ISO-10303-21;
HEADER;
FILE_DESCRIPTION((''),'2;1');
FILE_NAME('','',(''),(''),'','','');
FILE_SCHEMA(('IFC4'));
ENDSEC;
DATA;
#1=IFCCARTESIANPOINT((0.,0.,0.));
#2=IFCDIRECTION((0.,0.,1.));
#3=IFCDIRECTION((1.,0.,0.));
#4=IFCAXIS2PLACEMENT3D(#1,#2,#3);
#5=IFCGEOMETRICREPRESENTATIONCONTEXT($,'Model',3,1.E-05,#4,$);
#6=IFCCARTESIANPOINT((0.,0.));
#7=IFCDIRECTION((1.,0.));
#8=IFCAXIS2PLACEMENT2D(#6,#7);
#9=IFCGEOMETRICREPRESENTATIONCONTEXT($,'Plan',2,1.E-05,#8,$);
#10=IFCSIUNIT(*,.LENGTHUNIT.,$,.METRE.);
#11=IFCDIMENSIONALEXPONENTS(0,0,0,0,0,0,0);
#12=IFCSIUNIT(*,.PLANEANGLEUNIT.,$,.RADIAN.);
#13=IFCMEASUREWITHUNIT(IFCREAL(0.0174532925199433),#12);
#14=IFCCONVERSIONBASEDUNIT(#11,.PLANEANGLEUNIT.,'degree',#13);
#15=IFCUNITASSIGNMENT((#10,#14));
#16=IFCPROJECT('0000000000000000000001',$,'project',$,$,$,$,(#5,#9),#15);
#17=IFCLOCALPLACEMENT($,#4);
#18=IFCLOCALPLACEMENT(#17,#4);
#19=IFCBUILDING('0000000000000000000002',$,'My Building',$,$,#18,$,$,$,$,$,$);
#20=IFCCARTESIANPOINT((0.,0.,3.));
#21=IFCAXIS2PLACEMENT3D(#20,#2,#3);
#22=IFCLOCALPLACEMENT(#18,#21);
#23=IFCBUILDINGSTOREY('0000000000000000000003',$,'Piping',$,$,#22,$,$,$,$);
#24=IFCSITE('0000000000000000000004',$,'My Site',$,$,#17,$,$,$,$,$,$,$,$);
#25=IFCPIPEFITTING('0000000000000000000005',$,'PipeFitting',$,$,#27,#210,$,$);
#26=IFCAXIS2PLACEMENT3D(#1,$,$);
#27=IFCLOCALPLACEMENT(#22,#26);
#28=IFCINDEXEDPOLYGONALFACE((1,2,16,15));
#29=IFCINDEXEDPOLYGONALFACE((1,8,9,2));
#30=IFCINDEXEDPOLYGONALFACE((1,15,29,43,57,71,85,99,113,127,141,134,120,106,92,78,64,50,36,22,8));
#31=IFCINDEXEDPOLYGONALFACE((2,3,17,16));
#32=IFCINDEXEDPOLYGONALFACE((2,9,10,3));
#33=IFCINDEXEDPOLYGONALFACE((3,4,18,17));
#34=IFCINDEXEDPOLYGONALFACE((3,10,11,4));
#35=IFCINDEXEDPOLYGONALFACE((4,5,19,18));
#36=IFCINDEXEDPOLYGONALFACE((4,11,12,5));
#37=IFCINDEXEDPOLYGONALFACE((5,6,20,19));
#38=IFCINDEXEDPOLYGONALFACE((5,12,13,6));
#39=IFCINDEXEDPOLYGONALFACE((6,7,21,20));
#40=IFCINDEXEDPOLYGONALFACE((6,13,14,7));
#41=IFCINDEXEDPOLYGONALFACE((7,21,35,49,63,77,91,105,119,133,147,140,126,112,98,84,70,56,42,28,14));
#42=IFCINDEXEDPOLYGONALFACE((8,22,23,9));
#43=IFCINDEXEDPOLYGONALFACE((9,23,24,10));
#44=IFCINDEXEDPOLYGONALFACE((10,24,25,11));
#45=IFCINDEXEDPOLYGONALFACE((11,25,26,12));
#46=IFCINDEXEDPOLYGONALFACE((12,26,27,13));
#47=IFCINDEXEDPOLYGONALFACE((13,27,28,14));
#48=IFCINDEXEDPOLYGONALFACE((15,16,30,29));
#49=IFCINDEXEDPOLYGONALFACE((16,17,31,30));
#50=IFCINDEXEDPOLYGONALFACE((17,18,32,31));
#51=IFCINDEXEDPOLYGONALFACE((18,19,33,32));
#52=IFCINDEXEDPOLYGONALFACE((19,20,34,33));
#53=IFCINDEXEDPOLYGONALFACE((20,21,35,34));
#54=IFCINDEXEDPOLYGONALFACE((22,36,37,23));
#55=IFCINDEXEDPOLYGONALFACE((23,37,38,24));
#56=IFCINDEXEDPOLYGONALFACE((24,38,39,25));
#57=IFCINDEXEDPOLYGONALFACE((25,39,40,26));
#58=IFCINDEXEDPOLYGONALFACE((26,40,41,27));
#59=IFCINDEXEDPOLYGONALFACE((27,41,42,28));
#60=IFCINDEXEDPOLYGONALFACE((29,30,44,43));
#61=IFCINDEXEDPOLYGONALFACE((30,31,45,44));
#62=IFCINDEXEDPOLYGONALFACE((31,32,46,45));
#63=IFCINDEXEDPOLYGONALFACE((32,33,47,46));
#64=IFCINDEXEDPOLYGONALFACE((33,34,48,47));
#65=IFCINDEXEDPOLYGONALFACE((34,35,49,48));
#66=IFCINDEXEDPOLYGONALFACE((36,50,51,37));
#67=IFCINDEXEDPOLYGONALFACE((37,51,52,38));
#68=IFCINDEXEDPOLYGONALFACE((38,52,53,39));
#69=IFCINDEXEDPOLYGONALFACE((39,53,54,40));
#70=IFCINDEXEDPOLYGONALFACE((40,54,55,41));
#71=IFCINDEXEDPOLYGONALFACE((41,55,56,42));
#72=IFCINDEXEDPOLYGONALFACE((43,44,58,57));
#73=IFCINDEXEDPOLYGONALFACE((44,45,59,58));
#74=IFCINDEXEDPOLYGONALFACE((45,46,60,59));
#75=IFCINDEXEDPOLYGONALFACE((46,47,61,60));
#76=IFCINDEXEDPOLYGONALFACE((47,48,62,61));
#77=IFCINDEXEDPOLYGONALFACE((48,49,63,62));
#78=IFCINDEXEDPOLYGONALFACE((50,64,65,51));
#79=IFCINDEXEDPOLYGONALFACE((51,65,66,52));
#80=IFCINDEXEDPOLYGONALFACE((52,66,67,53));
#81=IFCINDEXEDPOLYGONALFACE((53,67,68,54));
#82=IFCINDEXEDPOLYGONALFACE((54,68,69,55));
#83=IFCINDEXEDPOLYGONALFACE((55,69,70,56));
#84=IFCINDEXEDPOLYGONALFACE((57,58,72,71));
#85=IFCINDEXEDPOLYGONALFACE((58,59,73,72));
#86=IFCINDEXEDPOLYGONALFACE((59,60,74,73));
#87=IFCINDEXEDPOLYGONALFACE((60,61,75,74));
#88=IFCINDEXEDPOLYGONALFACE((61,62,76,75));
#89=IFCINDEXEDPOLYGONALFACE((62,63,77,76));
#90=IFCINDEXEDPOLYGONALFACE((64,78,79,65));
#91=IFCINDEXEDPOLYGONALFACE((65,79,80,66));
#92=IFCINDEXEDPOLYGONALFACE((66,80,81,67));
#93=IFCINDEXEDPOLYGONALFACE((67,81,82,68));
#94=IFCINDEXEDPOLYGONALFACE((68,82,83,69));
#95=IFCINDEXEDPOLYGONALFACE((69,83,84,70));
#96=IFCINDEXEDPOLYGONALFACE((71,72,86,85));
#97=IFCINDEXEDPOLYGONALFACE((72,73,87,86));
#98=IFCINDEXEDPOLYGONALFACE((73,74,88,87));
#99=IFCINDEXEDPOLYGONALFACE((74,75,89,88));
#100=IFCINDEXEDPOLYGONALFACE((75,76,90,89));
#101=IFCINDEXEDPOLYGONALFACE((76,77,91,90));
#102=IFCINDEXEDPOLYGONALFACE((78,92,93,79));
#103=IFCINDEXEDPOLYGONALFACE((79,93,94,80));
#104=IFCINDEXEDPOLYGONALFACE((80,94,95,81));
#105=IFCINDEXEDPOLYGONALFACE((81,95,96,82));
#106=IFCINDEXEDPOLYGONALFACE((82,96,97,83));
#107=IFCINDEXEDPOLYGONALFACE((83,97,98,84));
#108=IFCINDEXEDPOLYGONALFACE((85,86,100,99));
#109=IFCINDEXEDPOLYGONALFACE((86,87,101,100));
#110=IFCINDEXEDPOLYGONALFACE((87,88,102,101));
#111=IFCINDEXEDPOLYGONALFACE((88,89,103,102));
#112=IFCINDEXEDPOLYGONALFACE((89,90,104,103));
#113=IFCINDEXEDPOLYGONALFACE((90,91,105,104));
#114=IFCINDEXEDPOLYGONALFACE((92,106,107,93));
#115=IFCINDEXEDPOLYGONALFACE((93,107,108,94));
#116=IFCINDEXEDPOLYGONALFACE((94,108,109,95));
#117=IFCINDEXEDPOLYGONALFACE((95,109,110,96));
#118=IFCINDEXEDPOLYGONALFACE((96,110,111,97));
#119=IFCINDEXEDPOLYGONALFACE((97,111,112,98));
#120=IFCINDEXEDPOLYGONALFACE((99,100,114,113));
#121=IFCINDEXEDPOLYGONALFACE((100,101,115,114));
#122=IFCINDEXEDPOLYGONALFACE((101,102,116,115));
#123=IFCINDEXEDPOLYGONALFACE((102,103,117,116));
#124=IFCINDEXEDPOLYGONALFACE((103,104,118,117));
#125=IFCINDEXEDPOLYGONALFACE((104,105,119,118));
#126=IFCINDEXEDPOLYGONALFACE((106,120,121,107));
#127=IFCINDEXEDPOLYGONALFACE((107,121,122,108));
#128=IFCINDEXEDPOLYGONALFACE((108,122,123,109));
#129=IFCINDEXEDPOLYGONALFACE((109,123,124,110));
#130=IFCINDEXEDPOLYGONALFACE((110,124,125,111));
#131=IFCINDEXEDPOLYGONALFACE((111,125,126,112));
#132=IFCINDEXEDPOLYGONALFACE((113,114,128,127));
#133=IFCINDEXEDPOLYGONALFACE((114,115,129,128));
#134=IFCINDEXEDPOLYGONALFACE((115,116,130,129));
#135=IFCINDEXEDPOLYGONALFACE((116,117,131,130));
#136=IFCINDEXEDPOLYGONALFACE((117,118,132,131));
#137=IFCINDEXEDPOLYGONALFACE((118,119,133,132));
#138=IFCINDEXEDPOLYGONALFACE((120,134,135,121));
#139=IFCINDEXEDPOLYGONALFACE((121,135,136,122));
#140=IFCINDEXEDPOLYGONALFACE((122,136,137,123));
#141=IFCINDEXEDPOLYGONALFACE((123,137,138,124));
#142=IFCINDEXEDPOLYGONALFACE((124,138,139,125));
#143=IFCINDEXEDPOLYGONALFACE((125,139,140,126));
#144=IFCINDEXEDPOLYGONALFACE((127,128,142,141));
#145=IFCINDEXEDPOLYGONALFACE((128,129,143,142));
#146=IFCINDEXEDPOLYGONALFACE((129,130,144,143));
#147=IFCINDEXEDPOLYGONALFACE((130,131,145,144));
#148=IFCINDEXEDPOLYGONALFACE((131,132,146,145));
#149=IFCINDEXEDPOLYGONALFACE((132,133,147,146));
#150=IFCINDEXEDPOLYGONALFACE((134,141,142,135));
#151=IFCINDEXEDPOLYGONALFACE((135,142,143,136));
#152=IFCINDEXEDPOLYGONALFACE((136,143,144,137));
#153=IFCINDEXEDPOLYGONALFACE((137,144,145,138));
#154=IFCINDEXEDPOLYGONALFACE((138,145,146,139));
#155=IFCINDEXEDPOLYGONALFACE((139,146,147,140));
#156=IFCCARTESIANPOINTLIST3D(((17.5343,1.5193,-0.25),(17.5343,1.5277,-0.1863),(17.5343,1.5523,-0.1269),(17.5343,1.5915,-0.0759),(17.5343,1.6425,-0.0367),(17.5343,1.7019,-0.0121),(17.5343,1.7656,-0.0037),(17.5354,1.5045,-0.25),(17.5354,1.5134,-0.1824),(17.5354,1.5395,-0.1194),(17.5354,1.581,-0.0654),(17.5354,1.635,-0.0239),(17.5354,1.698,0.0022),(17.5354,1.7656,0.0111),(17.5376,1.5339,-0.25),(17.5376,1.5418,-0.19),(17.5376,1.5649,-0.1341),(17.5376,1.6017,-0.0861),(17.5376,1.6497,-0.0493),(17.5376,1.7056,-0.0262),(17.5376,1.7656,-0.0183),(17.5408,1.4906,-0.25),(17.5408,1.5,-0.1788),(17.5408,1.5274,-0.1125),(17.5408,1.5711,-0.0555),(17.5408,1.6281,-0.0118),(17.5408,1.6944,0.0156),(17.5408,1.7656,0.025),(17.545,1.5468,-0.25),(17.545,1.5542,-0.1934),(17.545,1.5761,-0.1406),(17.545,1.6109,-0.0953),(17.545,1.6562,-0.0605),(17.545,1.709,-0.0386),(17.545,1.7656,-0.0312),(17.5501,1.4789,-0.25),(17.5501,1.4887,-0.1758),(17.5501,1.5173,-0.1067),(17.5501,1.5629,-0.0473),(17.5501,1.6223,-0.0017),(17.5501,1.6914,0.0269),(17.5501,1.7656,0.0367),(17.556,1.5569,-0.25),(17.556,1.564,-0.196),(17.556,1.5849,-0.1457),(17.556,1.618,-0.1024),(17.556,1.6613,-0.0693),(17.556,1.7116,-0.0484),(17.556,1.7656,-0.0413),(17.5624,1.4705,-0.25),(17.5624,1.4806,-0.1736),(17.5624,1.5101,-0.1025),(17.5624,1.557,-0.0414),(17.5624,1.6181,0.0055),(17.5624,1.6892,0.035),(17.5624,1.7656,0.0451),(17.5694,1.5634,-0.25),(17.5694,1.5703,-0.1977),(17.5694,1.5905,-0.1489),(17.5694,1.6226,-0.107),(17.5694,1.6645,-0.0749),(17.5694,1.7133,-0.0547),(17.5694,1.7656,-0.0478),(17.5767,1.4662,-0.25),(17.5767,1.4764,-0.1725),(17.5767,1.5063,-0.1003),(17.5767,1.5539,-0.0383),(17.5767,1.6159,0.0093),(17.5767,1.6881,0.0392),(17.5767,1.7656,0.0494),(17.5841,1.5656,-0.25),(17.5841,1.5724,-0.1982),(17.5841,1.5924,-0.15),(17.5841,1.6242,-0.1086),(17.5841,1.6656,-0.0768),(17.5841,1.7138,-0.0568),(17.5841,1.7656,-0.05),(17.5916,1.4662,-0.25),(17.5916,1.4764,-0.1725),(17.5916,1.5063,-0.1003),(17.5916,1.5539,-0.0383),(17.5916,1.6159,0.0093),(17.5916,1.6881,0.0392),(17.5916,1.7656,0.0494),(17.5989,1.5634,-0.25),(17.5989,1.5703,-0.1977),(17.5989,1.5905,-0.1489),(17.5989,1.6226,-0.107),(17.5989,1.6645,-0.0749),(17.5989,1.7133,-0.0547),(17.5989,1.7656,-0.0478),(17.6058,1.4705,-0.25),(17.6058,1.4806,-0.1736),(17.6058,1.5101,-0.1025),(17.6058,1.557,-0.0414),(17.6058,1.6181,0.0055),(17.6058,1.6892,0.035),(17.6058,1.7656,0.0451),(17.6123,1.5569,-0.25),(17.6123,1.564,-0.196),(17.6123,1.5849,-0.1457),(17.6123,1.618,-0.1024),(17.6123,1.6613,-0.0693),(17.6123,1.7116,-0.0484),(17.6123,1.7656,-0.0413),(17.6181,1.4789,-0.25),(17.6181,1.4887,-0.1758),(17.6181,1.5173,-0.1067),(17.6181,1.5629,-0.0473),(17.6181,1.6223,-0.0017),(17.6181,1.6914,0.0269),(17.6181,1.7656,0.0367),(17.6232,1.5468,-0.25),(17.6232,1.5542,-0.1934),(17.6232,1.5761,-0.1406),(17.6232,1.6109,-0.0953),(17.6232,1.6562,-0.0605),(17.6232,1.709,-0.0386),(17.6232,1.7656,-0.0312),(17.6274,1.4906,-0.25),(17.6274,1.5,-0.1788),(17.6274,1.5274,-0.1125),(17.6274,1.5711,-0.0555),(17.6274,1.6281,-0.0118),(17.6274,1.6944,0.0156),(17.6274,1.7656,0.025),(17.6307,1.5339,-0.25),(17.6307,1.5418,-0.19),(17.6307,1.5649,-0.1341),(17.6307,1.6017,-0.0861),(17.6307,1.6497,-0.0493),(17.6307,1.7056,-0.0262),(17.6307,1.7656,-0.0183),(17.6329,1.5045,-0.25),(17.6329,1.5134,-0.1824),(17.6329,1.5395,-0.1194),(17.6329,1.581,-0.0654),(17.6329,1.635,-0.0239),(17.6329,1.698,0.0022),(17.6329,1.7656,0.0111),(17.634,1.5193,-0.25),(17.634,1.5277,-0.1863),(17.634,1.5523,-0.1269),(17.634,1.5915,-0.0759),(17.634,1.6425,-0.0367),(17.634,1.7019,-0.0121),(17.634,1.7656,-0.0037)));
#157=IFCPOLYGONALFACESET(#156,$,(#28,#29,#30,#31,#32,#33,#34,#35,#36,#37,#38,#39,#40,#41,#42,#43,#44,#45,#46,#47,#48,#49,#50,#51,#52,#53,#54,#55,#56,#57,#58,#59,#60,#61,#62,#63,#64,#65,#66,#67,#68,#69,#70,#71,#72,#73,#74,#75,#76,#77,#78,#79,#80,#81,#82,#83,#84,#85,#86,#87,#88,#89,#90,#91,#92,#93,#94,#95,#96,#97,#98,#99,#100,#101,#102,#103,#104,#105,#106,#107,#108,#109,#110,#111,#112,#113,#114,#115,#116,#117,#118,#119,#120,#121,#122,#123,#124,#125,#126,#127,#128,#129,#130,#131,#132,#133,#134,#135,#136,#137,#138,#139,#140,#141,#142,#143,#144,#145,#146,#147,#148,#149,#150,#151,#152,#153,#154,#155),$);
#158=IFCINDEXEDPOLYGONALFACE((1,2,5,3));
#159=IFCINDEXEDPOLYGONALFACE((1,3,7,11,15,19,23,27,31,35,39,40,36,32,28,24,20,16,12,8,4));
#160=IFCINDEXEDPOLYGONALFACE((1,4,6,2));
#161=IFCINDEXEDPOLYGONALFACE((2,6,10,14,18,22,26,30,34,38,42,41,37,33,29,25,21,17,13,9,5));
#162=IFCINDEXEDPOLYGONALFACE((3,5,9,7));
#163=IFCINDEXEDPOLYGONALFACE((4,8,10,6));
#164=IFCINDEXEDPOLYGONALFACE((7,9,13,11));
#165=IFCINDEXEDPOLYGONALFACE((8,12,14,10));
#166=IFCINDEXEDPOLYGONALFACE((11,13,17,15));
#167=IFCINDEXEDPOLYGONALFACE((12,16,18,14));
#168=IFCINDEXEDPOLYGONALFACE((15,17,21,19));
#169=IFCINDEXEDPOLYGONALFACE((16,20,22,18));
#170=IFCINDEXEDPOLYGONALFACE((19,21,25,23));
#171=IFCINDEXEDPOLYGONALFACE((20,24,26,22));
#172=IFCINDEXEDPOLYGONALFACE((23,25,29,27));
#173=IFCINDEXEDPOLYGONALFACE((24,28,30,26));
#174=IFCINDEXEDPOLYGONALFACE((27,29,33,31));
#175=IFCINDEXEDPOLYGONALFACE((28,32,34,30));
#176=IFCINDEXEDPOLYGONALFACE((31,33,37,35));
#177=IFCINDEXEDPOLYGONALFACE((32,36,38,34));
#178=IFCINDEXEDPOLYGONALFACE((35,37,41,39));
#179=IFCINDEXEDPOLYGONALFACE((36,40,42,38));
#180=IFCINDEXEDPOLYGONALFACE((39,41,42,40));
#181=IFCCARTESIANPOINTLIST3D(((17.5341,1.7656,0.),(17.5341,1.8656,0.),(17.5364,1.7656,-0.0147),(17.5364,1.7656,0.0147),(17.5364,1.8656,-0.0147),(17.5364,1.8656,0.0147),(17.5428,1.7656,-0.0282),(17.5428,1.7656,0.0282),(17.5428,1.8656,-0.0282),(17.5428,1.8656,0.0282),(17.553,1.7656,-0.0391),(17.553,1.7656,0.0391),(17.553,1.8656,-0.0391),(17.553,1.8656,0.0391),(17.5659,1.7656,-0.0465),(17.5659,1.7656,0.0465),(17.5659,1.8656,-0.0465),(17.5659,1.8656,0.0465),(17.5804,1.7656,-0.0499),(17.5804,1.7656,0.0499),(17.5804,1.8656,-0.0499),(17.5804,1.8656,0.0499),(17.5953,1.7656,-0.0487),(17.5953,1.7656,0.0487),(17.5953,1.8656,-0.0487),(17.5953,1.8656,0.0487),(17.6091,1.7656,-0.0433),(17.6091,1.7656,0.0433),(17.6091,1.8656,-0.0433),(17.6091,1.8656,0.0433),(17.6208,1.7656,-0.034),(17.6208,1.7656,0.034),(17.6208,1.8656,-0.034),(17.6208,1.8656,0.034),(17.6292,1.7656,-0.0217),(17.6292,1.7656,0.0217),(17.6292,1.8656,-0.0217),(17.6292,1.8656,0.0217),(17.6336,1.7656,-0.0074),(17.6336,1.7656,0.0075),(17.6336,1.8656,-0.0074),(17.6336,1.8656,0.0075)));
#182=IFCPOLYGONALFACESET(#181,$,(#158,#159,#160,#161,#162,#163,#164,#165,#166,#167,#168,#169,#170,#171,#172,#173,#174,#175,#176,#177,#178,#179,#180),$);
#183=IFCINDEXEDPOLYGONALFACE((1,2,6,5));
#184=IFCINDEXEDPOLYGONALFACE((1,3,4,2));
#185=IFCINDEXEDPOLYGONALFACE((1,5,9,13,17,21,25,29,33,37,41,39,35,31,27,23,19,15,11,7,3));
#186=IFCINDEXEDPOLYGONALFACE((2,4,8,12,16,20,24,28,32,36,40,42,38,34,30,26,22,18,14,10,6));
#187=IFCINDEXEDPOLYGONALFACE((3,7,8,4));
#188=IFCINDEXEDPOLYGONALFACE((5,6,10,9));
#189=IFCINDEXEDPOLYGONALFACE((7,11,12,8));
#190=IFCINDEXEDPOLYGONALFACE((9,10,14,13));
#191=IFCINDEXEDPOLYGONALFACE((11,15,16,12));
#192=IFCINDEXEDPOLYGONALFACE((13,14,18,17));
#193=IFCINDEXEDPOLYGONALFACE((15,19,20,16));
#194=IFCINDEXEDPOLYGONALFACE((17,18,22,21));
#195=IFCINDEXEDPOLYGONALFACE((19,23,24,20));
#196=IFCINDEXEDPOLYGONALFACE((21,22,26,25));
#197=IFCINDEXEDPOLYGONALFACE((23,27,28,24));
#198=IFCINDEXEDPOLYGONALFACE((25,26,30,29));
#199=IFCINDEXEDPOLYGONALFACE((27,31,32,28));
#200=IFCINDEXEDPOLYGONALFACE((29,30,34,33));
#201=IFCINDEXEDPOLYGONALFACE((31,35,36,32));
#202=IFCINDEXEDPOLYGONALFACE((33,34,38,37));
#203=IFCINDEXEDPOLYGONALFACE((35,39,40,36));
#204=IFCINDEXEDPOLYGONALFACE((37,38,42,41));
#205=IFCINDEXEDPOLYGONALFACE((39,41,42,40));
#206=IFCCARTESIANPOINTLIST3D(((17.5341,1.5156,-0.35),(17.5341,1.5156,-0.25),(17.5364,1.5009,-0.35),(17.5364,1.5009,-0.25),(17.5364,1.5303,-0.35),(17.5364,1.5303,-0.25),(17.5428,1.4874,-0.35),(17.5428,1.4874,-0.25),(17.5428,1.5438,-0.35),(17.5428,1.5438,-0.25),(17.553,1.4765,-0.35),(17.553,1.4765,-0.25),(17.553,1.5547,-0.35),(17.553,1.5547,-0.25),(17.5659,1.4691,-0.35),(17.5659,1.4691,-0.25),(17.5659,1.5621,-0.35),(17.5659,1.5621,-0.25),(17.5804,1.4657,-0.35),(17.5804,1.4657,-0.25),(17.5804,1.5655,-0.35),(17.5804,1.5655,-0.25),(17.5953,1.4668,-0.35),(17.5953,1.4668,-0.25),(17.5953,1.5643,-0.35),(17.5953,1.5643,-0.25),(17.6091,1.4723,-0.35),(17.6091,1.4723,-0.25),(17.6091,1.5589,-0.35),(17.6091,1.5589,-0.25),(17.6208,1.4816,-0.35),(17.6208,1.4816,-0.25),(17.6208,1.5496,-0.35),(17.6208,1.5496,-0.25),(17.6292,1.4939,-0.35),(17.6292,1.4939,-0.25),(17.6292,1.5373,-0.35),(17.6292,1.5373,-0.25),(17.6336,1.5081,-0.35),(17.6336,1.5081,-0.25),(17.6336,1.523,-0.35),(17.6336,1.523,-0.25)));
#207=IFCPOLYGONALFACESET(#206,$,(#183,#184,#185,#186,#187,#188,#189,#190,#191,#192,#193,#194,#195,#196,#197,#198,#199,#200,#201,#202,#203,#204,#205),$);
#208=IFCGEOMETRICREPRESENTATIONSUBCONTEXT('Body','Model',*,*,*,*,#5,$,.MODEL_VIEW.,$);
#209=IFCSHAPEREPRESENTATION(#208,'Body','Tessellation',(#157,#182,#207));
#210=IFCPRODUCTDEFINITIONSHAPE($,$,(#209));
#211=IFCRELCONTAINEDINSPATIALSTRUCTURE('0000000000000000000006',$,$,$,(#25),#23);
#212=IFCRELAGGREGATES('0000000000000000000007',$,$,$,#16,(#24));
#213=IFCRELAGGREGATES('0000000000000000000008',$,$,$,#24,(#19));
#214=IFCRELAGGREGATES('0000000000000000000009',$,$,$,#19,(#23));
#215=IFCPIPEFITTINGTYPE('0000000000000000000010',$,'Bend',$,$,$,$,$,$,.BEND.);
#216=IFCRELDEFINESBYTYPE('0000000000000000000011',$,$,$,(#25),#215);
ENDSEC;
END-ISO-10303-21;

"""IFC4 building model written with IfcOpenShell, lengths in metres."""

from ifc_helpers import new_model, entity, si_unit, converted_unit, frame, origin_with_axes, origin_2d_with_axis, place, context, subcontext, project, spatial, circle, extrude, source, transform, mapped, type_object, type_shapes, element, save


model = new_model("IFC4")

# Units and contexts
model_context = context("Model", 3, precision=1e-05, world=origin_with_axes())
plan_context = context("Plan", 2, precision=1e-05, world=origin_2d_with_axis())
body_context = subcontext(model_context, "Body", "Model", "MODEL_VIEW")
ifc_project = project(units=[si_unit("LENGTHUNIT", "METRE"), converted_unit("PLANEANGLEUNIT", "degree", entity("IfcReal", 0.0174532925199433), si_unit("PLANEANGLEUNIT", "RADIAN"), dimensions=[0, 0, 0, 0, 0, 0, 0])], contexts=[model_context, plan_context])

# Site, building, storey
site_placement = place(None, origin_with_axes())
site = spatial("IfcSite", under=ifc_project, at=site_placement, Name="My Site")
building_placement = place(site_placement, origin_with_axes())
building = spatial("IfcBuilding", under=site, at=building_placement, Name="My Building")
storey_placement = place(building_placement, frame((0.0, 0.0, 3.0), z_axis=(0.0, 0.0, 1.0), x_axis=(1.0, 0.0, 0.0)))
storey = spatial("IfcBuildingStorey", under=building, at=storey_placement, Name="Piping")

# Shared definitions
pipe_fitting_type = type_object("IfcPipeFittingType", Name="Bend", PredefinedType="BEND")
shared_shape = source(origin_with_axes(), body_context, "Body", "SolidModel", [
    entity("IfcSweptDiskSolid", entity("IfcIndexedPolyCurve", entity("IfcCartesianPointList3D", [[0.0, 0.0, -0.1], [0.0, -0.0732, -0.2768], [0.0, -0.25, -0.35]]), [entity("IfcArcIndex", [1, 2, 3])]), 0.05),
    extrude(circle(Radius=0.05), origin_with_axes(), (0.0, 0.0, -1.0), 0.1),
    extrude(circle(Radius=0.05), frame((0.0, -0.25, -0.35), z_axis=(0.0, -1.0, 0.0), x_axis=(1.0, 0.0, 0.0)), (0.0, 0.0, 1.0), 0.1),
])
type_shapes(pipe_fitting_type, [shared_shape])

# Pipe fitting
for number, where, z_axis, x_axis, name in (
    (1, (17.5841, 1.8656, 0.0), (0.0, 1.0, 0.0), (-1.0, 0.0, 0.0), "PipeFitting"),
):
    element("IfcPipeFitting", number, at=place(storey_placement, frame(where, z_axis=z_axis, x_axis=x_axis)), inside=storey, type_object=pipe_fitting_type, Name=name, context=body_context, shape_type="MappedRepresentation", body=[
        mapped(shared_shape, transform((0.0, 0.0, 0.0), x_axis=(1.0, 0.0, 0.0), y_axis=(0.0, 1.0, 0.0), z_axis=(0.0, 0.0, 1.0), scale=1.0)),
    ])

save(model, "model.ifc")
